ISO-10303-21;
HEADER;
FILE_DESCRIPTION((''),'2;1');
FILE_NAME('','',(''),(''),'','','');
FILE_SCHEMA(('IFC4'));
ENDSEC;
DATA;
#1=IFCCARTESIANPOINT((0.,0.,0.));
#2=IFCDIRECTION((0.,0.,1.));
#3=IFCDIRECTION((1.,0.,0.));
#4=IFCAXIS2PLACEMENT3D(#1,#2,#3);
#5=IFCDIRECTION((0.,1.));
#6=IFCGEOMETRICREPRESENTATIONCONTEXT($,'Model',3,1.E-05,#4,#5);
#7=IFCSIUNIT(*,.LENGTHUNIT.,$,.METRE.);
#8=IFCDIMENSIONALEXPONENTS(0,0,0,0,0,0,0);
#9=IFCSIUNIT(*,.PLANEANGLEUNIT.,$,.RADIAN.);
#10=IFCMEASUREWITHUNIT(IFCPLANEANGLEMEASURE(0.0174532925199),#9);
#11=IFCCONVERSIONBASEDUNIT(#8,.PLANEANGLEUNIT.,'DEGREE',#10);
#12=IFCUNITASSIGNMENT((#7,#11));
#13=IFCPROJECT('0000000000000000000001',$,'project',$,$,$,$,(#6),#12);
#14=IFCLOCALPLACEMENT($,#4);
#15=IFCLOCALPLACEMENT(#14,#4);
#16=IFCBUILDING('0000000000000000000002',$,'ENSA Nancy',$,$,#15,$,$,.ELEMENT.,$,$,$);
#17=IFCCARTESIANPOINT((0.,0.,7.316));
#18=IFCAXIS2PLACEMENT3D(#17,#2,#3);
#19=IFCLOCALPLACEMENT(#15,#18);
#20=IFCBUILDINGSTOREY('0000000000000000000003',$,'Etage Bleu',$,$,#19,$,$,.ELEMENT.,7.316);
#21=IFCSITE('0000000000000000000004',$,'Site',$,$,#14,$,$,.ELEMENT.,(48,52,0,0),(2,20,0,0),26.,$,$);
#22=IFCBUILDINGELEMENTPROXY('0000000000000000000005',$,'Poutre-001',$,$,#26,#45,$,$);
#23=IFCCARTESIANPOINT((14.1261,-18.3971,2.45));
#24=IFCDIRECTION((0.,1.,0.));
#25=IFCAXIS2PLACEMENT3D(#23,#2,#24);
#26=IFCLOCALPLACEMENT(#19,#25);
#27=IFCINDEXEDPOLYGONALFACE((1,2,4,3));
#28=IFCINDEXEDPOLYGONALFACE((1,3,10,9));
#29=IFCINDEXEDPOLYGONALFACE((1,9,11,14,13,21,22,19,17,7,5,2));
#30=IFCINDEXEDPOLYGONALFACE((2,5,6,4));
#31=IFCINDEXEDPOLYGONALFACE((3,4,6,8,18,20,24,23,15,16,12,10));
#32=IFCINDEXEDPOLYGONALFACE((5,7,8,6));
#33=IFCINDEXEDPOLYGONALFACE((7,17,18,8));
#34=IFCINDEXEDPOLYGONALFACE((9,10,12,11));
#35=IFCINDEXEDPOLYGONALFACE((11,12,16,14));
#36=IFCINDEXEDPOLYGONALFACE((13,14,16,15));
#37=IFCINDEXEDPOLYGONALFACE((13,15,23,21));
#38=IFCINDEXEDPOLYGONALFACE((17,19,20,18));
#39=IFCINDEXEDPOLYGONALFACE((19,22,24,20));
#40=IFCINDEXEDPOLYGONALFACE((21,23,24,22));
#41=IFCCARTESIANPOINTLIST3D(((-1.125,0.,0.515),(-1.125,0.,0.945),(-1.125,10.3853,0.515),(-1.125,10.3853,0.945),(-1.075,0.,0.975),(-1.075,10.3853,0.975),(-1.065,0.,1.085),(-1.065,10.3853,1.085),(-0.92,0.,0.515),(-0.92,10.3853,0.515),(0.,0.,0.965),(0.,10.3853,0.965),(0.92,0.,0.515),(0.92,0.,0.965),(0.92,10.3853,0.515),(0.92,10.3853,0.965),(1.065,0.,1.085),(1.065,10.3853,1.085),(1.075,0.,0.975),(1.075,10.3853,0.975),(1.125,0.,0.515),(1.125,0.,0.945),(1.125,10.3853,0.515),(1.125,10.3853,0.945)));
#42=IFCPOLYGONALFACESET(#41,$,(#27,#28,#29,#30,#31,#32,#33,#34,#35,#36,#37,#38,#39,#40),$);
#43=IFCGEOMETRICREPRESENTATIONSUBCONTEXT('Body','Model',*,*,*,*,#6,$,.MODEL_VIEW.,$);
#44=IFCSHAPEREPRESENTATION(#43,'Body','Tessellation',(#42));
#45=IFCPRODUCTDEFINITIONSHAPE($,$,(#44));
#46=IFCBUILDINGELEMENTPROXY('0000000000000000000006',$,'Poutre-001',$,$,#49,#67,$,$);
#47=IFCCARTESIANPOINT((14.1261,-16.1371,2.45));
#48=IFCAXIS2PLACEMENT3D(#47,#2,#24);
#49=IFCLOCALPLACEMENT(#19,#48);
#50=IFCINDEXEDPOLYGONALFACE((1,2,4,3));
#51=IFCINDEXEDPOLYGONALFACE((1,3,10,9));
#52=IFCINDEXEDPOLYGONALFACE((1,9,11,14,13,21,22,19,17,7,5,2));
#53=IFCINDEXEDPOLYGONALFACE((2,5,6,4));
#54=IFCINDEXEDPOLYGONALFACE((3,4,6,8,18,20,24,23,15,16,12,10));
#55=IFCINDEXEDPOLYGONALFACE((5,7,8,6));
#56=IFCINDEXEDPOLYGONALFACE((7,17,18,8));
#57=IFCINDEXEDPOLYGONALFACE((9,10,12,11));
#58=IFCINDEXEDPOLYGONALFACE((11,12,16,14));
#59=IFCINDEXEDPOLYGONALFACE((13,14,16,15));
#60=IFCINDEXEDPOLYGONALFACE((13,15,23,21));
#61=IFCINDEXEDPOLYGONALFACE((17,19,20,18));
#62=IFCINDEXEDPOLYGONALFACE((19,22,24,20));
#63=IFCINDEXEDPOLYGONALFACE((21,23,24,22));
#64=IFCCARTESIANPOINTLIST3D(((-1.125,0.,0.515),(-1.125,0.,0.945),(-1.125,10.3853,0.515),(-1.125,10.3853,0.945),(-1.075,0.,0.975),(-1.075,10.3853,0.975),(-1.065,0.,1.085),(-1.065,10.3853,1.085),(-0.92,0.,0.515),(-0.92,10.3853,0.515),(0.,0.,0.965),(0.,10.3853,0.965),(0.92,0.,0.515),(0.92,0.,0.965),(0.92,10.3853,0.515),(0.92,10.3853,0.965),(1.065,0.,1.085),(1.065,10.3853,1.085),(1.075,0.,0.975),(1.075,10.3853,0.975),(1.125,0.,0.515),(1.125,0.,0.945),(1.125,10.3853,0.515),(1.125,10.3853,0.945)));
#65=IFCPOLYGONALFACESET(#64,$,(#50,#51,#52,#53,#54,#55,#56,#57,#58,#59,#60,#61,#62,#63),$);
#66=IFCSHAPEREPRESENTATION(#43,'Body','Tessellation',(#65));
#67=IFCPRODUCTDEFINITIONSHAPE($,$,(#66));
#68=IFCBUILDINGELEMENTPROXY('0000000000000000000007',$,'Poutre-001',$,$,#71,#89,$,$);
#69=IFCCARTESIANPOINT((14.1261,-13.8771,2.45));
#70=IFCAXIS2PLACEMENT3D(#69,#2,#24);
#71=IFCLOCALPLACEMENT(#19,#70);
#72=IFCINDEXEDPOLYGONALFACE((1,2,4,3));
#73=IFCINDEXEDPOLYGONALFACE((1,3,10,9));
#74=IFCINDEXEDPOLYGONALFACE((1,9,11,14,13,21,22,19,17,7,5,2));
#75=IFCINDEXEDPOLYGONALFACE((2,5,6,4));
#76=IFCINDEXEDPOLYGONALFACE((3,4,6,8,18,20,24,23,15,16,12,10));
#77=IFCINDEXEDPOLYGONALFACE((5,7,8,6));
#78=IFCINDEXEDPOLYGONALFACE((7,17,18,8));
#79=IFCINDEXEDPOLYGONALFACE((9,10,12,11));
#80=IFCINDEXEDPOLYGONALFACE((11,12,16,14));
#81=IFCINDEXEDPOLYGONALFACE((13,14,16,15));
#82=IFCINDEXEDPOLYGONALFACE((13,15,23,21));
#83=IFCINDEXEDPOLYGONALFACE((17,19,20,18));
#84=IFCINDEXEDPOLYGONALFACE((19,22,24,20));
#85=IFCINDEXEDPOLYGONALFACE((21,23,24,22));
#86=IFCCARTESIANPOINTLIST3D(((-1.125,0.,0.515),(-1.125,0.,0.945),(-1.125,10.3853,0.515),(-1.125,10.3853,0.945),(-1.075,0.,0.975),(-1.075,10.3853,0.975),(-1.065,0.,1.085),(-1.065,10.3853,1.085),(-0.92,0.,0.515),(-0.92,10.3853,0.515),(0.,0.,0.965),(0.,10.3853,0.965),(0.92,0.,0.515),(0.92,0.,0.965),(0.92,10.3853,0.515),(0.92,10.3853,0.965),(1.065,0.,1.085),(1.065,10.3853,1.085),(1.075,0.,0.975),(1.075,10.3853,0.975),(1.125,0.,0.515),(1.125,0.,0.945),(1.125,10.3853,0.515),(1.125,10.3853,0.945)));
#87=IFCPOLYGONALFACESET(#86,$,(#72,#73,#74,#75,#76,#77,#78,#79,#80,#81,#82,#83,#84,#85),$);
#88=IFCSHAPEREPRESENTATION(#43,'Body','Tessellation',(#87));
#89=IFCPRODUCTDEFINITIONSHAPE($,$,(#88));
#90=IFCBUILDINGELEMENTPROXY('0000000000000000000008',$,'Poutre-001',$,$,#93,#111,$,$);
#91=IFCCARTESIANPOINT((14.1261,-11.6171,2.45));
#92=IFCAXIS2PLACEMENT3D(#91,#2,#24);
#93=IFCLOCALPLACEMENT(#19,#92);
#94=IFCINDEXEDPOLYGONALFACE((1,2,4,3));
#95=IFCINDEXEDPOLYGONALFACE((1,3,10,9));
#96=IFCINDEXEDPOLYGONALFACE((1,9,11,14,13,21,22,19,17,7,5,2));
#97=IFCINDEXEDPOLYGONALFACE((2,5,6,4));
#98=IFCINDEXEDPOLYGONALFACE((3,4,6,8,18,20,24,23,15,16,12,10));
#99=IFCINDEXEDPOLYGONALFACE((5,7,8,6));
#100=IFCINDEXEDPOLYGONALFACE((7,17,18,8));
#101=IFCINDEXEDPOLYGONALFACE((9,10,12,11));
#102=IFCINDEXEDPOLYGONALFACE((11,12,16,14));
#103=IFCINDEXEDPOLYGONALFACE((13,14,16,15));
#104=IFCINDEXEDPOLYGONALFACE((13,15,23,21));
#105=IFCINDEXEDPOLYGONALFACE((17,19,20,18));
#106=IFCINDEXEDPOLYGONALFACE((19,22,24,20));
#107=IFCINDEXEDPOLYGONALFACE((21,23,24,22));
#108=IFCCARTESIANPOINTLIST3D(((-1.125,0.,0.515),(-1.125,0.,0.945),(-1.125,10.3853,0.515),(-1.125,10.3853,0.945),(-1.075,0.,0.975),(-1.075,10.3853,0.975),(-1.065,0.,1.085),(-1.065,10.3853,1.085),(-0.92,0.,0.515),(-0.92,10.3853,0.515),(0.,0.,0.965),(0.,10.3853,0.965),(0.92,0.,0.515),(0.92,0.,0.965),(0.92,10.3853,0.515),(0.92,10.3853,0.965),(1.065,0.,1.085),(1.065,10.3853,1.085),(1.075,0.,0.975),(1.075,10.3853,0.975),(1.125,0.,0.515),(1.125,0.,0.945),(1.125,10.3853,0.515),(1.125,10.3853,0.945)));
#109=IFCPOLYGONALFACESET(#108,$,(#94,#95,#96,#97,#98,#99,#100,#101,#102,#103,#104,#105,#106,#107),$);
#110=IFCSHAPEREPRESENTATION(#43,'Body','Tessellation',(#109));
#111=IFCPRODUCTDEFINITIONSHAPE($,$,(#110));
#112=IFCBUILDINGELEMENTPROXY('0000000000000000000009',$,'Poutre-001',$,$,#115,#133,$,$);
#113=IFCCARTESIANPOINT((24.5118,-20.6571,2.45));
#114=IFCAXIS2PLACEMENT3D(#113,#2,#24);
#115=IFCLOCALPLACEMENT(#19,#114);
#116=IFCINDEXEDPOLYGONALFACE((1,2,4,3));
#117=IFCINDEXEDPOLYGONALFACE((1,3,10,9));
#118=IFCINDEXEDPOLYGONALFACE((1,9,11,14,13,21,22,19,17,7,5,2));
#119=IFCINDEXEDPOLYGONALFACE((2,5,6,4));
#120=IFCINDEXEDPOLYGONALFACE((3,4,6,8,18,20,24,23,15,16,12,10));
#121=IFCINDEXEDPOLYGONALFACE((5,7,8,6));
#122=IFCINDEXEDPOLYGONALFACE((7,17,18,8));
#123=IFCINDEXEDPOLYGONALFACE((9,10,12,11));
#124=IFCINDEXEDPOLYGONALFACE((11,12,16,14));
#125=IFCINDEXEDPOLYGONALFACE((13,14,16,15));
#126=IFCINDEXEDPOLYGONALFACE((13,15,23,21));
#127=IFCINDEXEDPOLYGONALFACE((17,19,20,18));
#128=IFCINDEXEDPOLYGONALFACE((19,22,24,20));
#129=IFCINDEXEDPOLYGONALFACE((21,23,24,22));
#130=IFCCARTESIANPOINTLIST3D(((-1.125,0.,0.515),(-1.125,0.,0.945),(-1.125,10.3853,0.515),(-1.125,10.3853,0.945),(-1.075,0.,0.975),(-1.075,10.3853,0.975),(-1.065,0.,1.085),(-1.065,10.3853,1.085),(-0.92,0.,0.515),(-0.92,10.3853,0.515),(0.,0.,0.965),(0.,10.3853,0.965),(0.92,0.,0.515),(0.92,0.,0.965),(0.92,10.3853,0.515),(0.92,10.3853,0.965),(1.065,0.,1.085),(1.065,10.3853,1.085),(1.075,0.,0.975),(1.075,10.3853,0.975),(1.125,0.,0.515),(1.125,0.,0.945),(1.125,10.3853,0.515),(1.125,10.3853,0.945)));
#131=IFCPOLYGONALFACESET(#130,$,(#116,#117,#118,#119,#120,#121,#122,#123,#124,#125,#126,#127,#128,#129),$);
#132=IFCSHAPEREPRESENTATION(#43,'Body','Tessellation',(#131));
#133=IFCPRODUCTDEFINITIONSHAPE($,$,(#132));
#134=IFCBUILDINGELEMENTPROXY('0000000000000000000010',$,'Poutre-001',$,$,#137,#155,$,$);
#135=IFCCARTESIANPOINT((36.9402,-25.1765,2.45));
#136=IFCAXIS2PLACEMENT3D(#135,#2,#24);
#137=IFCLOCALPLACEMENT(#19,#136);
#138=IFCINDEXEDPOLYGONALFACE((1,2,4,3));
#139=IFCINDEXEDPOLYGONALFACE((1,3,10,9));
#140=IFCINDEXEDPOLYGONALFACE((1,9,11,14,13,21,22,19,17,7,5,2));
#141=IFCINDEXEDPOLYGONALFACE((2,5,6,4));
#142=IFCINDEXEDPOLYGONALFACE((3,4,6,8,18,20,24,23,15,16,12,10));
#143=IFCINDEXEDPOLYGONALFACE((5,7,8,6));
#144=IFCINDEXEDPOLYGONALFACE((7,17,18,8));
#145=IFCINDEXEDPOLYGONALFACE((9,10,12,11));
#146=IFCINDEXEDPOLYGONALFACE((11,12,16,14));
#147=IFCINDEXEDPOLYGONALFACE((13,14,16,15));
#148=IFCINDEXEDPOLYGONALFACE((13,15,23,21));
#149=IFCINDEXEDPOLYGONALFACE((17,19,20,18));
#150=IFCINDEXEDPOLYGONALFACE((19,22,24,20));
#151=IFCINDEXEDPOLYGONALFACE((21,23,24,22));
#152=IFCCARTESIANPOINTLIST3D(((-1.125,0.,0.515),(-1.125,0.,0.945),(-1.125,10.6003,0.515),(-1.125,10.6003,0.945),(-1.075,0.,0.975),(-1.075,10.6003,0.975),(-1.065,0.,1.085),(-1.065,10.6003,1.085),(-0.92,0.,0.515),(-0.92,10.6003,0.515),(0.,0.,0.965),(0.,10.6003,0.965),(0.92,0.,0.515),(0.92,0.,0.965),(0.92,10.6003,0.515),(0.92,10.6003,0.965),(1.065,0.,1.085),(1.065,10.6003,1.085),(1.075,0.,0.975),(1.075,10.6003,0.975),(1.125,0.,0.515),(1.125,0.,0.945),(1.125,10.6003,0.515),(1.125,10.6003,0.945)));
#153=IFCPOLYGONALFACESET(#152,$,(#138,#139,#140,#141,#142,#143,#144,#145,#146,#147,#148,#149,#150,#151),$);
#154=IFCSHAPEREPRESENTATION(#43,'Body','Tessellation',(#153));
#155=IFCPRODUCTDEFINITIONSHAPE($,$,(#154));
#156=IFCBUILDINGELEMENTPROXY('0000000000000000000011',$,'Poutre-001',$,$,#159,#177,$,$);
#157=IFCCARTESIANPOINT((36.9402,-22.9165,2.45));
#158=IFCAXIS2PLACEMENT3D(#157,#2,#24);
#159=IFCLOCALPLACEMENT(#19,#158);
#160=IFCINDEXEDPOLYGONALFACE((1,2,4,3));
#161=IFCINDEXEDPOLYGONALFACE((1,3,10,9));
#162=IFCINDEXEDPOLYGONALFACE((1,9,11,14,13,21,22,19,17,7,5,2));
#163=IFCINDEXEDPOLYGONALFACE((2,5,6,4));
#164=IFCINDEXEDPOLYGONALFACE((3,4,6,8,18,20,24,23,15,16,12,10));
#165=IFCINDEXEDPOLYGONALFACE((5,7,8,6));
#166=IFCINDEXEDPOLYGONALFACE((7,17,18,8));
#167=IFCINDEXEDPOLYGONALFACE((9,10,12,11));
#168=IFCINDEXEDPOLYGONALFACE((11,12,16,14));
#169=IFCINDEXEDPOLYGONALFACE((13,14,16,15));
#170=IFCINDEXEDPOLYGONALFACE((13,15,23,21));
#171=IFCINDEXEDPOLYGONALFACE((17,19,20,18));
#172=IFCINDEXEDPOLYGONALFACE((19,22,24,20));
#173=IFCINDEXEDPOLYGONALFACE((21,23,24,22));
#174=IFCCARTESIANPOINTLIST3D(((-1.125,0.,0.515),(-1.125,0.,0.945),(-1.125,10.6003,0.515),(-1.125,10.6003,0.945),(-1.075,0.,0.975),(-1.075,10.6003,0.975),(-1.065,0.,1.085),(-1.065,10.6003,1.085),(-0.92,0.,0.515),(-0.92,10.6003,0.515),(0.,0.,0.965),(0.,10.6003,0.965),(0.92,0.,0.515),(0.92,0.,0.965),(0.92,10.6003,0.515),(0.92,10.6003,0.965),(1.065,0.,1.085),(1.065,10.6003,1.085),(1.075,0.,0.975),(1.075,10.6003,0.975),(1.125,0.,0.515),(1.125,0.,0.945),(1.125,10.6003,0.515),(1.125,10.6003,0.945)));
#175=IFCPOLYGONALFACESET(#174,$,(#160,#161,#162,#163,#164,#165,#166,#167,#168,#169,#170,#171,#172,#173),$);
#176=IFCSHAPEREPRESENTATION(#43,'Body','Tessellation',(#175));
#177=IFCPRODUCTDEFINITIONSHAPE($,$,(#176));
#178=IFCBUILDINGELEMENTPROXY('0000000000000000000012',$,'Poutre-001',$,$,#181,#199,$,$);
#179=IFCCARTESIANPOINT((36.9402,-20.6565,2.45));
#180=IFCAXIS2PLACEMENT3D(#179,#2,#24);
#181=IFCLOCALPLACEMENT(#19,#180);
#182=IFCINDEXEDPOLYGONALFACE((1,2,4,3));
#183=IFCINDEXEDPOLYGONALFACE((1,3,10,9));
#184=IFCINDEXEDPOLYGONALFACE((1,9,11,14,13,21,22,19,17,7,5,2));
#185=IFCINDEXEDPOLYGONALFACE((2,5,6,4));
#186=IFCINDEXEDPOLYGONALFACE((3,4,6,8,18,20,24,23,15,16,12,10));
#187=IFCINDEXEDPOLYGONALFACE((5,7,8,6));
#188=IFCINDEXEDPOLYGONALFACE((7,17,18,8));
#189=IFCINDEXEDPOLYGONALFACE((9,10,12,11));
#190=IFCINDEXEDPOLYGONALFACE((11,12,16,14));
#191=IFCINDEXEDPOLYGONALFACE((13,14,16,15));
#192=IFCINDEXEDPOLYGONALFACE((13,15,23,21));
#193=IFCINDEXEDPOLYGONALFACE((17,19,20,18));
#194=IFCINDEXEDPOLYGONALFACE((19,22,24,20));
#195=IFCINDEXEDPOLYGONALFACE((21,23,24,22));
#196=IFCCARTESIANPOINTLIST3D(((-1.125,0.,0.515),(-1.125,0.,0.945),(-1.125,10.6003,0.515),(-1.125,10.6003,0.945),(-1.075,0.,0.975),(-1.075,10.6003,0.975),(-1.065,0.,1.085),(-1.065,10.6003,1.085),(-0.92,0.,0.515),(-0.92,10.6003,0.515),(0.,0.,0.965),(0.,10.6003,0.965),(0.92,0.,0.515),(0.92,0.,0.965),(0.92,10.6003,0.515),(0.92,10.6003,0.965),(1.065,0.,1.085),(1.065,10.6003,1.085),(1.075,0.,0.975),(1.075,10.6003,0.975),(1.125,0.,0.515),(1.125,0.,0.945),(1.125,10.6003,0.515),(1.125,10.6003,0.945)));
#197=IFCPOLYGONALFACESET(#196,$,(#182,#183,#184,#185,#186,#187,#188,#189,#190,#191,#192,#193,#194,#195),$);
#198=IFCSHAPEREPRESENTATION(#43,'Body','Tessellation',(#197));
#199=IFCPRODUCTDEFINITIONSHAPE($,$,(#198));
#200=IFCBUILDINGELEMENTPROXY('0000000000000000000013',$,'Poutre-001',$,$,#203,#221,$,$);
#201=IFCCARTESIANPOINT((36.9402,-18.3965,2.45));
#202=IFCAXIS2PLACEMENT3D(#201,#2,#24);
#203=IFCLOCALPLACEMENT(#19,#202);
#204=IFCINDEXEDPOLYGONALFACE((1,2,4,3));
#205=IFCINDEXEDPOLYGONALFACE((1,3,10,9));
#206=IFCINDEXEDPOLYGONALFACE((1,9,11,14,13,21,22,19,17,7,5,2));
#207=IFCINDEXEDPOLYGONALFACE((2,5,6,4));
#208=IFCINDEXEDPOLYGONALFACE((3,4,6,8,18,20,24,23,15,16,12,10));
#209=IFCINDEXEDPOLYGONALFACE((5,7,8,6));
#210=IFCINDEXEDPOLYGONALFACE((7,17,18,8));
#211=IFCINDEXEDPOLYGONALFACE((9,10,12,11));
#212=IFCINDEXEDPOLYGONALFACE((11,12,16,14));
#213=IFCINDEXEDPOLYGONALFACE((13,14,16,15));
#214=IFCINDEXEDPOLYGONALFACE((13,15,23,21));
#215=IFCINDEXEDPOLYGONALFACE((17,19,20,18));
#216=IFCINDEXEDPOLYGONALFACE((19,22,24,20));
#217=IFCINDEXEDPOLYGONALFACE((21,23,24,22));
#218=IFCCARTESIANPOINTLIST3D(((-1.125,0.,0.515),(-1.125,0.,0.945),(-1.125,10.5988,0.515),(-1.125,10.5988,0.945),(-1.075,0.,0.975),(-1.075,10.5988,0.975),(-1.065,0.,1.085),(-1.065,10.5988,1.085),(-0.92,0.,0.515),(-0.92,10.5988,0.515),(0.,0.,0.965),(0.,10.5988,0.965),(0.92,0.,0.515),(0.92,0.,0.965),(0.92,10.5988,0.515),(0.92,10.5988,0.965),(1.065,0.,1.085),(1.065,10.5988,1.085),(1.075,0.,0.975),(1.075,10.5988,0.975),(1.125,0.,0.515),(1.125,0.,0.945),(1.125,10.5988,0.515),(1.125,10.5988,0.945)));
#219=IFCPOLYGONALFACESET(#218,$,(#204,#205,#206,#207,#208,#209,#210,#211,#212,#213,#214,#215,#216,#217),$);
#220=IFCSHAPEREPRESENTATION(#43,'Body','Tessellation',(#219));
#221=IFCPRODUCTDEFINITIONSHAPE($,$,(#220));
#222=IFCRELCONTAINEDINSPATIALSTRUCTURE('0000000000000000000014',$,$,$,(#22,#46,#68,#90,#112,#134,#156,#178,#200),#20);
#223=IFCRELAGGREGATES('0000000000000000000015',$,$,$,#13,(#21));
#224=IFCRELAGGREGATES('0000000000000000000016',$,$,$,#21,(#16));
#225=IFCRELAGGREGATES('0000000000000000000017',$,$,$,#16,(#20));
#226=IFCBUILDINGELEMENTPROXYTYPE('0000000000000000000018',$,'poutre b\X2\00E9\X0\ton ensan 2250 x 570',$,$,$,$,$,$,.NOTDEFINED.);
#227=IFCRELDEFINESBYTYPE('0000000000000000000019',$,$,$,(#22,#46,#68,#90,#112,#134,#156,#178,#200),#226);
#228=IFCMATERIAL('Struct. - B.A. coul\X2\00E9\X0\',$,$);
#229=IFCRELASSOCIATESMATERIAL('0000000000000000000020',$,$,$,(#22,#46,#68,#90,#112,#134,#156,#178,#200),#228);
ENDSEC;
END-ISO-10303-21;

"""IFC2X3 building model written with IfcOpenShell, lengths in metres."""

from ifc_helpers import new_model, entity, si_unit, converted_unit, direction, frame, origin_with_axes, place, context, subcontext, project, spatial, polyline, outline, extrude, material, type_object, element, save


model = new_model("IFC2X3")

# Units and contexts
model_context = context("Model", 3, precision=1e-05, world=origin_with_axes(), true_north=direction((0.0, 1.0)))
body_context = subcontext(model_context, "Body", "Model", "MODEL_VIEW")
ifc_project = project(units=[si_unit("LENGTHUNIT", "METRE"), converted_unit("PLANEANGLEUNIT", "DEGREE", entity("IfcPlaneAngleMeasure", 0.0174532925199), si_unit("PLANEANGLEUNIT", "RADIAN"), dimensions=[0, 0, 0, 0, 0, 0, 0])], contexts=[model_context])

# Site, building, storey
site_placement = place(None, origin_with_axes())
site = spatial("IfcSite", under=ifc_project, at=site_placement, Name="Site", CompositionType="ELEMENT", RefLatitude=(48, 52, 0, 0), RefLongitude=(2, 20, 0, 0), RefElevation=26.0)
building_placement = place(site_placement, origin_with_axes())
building = spatial("IfcBuilding", under=site, at=building_placement, Name="ENSA Nancy", CompositionType="ELEMENT")
storey_placement = place(building_placement, frame((0.0, 0.0, 7.316), z_axis=(0.0, 0.0, 1.0), x_axis=(1.0, 0.0, 0.0)))
storey = spatial("IfcBuildingStorey", under=building, at=storey_placement, Name="Etage Bleu", CompositionType="ELEMENT", Elevation=7.316)

# Building element proxies
ifc_material_1 = material(Name="Struct. - B.A. coulé")
building_element_proxy_type_1 = type_object("IfcBuildingElementProxyType", Name="poutre béton ensan 2250 x 570", PredefinedType="NOTDEFINED")
for number, where, z_axis, x_axis, name in (
    (1, (14.1261, -18.3971, 2.45), (0.0, 0.0, 1.0), (0.0, 1.0, 0.0), "Poutre-001"),
    (2, (14.1261, -16.1371, 2.45), (0.0, 0.0, 1.0), (0.0, 1.0, 0.0), "Poutre-001"),
    (3, (14.1261, -13.8771, 2.45), (0.0, 0.0, 1.0), (0.0, 1.0, 0.0), "Poutre-001"),
    (4, (14.1261, -11.6171, 2.45), (0.0, 0.0, 1.0), (0.0, 1.0, 0.0), "Poutre-001"),
    (5, (24.5118, -20.6571, 2.45), (0.0, 0.0, 1.0), (0.0, 1.0, 0.0), "Poutre-001"),
):
    element("IfcBuildingElementProxy", number, at=place(storey_placement, frame(where, z_axis=z_axis, x_axis=x_axis)), inside=storey, type_object=building_element_proxy_type_1, material=ifc_material_1, Name=name, context=body_context, shape_type="SweptSolid", body=[
        extrude(outline(polyline([(-1.065, 1.085), (-1.075, 0.975), (-1.125, 0.945), (-1.125, 0.515), (-0.92, 0.515), (0.0, 0.965), (0.92, 0.965), (0.92, 0.515), (1.125, 0.515), (1.125, 0.945), (1.075, 0.975), (1.065, 1.085), (-1.065, 1.085)])), frame((0.0, 10.3853, 0.0), z_axis=(0.0, -1.0, 0.0), x_axis=(1.0, 0.0, 0.0)), (0.0, 0.0, 1.0), 10.3853),
    ])
for number, where, z_axis, x_axis, name in (
    (6, (36.9402, -25.1765, 2.45), (0.0, 0.0, 1.0), (0.0, 1.0, 0.0), "Poutre-001"),
    (7, (36.9402, -22.9165, 2.45), (0.0, 0.0, 1.0), (0.0, 1.0, 0.0), "Poutre-001"),
    (8, (36.9402, -20.6565, 2.45), (0.0, 0.0, 1.0), (0.0, 1.0, 0.0), "Poutre-001"),
):
    element("IfcBuildingElementProxy", number, at=place(storey_placement, frame(where, z_axis=z_axis, x_axis=x_axis)), inside=storey, type_object=building_element_proxy_type_1, material=ifc_material_1, Name=name, context=body_context, shape_type="SweptSolid", body=[
        extrude(outline(polyline([(-1.065, 1.085), (-1.075, 0.975), (-1.125, 0.945), (-1.125, 0.515), (-0.92, 0.515), (0.0, 0.965), (0.92, 0.965), (0.92, 0.515), (1.125, 0.515), (1.125, 0.945), (1.075, 0.975), (1.065, 1.085), (-1.065, 1.085)])), frame((0.0, 10.6003, 0.0), z_axis=(0.0, -1.0, 0.0), x_axis=(1.0, 0.0, 0.0)), (0.0, 0.0, 1.0), 10.6003),
    ])
for number, where, z_axis, x_axis, name in (
    (9, (36.9402, -18.3965, 2.45), (0.0, 0.0, 1.0), (0.0, 1.0, 0.0), "Poutre-001"),
):
    element("IfcBuildingElementProxy", number, at=place(storey_placement, frame(where, z_axis=z_axis, x_axis=x_axis)), inside=storey, type_object=building_element_proxy_type_1, material=ifc_material_1, Name=name, context=body_context, shape_type="SweptSolid", body=[
        extrude(outline(polyline([(-1.065, 1.085), (-1.075, 0.975), (-1.125, 0.945), (-1.125, 0.515), (-0.92, 0.515), (0.0, 0.965), (0.92, 0.965), (0.92, 0.515), (1.125, 0.515), (1.125, 0.945), (1.075, 0.975), (1.065, 1.085), (-1.065, 1.085)])), frame((0.0, 10.5988, 0.0), z_axis=(0.0, -1.0, 0.0), x_axis=(1.0, 0.0, 0.0)), (0.0, 0.0, 1.0), 10.5988),
    ])

save(model, "model.ifc")
